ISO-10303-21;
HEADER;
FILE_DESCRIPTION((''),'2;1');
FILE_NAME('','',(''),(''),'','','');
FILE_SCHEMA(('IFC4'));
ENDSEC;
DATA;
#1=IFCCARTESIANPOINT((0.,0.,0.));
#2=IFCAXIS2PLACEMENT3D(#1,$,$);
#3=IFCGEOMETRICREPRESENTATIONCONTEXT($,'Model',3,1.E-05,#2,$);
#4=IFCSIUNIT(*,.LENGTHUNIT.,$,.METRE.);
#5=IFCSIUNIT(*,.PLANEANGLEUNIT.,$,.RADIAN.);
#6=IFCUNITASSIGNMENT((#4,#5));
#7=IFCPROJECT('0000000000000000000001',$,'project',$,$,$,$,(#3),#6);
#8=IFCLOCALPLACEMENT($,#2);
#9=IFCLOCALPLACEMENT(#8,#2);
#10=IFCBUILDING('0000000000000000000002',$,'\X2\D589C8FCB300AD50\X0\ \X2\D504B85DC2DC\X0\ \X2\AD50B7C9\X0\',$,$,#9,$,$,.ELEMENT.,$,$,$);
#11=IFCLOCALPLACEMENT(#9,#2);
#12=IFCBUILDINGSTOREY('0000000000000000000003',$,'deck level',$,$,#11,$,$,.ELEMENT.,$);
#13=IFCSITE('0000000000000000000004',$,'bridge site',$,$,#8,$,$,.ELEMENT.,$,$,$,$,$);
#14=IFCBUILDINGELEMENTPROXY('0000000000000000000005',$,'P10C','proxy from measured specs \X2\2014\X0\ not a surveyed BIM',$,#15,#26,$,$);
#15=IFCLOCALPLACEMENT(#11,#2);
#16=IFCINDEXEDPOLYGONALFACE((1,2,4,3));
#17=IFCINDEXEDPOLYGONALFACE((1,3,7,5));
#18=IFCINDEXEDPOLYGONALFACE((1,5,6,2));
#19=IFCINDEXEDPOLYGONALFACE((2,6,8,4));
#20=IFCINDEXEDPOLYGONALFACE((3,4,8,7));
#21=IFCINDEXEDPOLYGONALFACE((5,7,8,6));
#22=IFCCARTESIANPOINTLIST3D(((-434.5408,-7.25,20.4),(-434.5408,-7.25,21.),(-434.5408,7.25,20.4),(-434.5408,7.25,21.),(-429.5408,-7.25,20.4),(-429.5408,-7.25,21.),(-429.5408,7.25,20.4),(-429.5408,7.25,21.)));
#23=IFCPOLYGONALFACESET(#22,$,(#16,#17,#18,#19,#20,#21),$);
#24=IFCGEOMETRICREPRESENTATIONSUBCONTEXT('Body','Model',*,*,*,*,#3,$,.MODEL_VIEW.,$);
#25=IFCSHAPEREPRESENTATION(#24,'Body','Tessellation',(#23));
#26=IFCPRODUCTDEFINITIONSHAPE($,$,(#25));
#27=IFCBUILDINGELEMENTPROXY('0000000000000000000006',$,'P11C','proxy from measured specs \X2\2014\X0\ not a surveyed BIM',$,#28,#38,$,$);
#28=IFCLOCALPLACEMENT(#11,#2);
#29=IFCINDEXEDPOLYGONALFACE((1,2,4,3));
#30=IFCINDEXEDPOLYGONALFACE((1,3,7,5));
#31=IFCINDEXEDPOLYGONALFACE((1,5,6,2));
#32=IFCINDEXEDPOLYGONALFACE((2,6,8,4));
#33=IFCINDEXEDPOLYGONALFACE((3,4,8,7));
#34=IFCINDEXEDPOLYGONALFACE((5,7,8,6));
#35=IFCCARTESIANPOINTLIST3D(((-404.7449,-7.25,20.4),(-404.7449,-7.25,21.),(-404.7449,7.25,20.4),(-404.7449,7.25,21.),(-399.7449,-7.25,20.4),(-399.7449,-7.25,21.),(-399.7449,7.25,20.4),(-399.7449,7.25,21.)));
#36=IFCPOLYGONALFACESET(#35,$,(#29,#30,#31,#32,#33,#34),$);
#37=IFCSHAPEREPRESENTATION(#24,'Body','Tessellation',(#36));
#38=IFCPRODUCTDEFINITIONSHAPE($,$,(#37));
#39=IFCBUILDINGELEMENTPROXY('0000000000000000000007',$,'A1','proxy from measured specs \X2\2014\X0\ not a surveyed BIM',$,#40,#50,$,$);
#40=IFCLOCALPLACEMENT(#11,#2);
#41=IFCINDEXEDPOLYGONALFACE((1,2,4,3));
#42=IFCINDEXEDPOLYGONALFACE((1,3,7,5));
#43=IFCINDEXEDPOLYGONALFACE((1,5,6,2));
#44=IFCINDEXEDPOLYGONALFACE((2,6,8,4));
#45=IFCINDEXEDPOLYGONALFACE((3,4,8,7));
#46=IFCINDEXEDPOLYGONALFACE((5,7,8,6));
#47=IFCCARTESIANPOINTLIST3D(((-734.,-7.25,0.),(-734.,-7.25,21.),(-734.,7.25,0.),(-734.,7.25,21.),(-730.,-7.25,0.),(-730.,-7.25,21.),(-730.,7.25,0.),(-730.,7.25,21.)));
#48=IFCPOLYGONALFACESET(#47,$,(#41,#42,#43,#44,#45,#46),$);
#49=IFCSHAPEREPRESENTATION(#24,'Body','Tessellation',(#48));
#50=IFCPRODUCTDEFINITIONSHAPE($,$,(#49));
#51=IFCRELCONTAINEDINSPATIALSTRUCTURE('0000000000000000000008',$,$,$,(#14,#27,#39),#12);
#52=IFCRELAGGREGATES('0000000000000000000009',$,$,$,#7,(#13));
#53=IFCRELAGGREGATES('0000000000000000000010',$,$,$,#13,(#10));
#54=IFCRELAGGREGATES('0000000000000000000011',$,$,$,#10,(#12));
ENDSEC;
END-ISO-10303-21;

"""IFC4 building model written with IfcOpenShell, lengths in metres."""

from ifc_helpers import new_model, si_unit, frame, origin, origin_2d, place, context, subcontext, project, spatial, rectangle, extrude, element, save


model = new_model("IFC4")

# Units and contexts
model_context = context("Model", 3, precision=1e-05, world=origin())
body_context = subcontext(model_context, "Body", "Model", "MODEL_VIEW")
ifc_project = project(units=[si_unit("LENGTHUNIT", "METRE"), si_unit("PLANEANGLEUNIT", "RADIAN")], contexts=[model_context])

# Site, building, storey
site_placement = place(None, origin())
site = spatial("IfcSite", under=ifc_project, at=site_placement, Name="bridge site", CompositionType="ELEMENT")
building_placement = place(site_placement, origin())
building = spatial("IfcBuilding", under=site, at=building_placement, Name="행주대교 프록시 교량", CompositionType="ELEMENT")
storey_placement = place(building_placement, origin())
storey = spatial("IfcBuildingStorey", under=building, at=storey_placement, Name="deck level", CompositionType="ELEMENT")

# Building element proxies
for number, where, name in (
    (1, (-432.0408, 0.0, 20.4), "P10C"),
    (2, (-402.2449, 0.0, 20.4), "P11C"),
):
    element("IfcBuildingElementProxy", number, at=place(storey_placement, frame(where)), inside=storey, Name=name, Description="proxy from measured specs — not a surveyed BIM", context=body_context, shape_type="SweptSolid", body=[
        extrude(rectangle(XDim=5.0, YDim=14.5, at=origin_2d()), origin(), (0.0, 0.0, 1.0), 0.6),
    ])
proxy_placement = place(storey_placement, frame((-732.0, 0.0, 0.0)))
element("IfcBuildingElementProxy", 3, at=proxy_placement, inside=storey, Name="A1", Description="proxy from measured specs — not a surveyed BIM", context=body_context, shape_type="SweptSolid", body=[
    extrude(rectangle(XDim=4.0, YDim=14.5, at=origin_2d()), origin(), (0.0, 0.0, 1.0), 21.0),
])

save(model, "model.ifc")
